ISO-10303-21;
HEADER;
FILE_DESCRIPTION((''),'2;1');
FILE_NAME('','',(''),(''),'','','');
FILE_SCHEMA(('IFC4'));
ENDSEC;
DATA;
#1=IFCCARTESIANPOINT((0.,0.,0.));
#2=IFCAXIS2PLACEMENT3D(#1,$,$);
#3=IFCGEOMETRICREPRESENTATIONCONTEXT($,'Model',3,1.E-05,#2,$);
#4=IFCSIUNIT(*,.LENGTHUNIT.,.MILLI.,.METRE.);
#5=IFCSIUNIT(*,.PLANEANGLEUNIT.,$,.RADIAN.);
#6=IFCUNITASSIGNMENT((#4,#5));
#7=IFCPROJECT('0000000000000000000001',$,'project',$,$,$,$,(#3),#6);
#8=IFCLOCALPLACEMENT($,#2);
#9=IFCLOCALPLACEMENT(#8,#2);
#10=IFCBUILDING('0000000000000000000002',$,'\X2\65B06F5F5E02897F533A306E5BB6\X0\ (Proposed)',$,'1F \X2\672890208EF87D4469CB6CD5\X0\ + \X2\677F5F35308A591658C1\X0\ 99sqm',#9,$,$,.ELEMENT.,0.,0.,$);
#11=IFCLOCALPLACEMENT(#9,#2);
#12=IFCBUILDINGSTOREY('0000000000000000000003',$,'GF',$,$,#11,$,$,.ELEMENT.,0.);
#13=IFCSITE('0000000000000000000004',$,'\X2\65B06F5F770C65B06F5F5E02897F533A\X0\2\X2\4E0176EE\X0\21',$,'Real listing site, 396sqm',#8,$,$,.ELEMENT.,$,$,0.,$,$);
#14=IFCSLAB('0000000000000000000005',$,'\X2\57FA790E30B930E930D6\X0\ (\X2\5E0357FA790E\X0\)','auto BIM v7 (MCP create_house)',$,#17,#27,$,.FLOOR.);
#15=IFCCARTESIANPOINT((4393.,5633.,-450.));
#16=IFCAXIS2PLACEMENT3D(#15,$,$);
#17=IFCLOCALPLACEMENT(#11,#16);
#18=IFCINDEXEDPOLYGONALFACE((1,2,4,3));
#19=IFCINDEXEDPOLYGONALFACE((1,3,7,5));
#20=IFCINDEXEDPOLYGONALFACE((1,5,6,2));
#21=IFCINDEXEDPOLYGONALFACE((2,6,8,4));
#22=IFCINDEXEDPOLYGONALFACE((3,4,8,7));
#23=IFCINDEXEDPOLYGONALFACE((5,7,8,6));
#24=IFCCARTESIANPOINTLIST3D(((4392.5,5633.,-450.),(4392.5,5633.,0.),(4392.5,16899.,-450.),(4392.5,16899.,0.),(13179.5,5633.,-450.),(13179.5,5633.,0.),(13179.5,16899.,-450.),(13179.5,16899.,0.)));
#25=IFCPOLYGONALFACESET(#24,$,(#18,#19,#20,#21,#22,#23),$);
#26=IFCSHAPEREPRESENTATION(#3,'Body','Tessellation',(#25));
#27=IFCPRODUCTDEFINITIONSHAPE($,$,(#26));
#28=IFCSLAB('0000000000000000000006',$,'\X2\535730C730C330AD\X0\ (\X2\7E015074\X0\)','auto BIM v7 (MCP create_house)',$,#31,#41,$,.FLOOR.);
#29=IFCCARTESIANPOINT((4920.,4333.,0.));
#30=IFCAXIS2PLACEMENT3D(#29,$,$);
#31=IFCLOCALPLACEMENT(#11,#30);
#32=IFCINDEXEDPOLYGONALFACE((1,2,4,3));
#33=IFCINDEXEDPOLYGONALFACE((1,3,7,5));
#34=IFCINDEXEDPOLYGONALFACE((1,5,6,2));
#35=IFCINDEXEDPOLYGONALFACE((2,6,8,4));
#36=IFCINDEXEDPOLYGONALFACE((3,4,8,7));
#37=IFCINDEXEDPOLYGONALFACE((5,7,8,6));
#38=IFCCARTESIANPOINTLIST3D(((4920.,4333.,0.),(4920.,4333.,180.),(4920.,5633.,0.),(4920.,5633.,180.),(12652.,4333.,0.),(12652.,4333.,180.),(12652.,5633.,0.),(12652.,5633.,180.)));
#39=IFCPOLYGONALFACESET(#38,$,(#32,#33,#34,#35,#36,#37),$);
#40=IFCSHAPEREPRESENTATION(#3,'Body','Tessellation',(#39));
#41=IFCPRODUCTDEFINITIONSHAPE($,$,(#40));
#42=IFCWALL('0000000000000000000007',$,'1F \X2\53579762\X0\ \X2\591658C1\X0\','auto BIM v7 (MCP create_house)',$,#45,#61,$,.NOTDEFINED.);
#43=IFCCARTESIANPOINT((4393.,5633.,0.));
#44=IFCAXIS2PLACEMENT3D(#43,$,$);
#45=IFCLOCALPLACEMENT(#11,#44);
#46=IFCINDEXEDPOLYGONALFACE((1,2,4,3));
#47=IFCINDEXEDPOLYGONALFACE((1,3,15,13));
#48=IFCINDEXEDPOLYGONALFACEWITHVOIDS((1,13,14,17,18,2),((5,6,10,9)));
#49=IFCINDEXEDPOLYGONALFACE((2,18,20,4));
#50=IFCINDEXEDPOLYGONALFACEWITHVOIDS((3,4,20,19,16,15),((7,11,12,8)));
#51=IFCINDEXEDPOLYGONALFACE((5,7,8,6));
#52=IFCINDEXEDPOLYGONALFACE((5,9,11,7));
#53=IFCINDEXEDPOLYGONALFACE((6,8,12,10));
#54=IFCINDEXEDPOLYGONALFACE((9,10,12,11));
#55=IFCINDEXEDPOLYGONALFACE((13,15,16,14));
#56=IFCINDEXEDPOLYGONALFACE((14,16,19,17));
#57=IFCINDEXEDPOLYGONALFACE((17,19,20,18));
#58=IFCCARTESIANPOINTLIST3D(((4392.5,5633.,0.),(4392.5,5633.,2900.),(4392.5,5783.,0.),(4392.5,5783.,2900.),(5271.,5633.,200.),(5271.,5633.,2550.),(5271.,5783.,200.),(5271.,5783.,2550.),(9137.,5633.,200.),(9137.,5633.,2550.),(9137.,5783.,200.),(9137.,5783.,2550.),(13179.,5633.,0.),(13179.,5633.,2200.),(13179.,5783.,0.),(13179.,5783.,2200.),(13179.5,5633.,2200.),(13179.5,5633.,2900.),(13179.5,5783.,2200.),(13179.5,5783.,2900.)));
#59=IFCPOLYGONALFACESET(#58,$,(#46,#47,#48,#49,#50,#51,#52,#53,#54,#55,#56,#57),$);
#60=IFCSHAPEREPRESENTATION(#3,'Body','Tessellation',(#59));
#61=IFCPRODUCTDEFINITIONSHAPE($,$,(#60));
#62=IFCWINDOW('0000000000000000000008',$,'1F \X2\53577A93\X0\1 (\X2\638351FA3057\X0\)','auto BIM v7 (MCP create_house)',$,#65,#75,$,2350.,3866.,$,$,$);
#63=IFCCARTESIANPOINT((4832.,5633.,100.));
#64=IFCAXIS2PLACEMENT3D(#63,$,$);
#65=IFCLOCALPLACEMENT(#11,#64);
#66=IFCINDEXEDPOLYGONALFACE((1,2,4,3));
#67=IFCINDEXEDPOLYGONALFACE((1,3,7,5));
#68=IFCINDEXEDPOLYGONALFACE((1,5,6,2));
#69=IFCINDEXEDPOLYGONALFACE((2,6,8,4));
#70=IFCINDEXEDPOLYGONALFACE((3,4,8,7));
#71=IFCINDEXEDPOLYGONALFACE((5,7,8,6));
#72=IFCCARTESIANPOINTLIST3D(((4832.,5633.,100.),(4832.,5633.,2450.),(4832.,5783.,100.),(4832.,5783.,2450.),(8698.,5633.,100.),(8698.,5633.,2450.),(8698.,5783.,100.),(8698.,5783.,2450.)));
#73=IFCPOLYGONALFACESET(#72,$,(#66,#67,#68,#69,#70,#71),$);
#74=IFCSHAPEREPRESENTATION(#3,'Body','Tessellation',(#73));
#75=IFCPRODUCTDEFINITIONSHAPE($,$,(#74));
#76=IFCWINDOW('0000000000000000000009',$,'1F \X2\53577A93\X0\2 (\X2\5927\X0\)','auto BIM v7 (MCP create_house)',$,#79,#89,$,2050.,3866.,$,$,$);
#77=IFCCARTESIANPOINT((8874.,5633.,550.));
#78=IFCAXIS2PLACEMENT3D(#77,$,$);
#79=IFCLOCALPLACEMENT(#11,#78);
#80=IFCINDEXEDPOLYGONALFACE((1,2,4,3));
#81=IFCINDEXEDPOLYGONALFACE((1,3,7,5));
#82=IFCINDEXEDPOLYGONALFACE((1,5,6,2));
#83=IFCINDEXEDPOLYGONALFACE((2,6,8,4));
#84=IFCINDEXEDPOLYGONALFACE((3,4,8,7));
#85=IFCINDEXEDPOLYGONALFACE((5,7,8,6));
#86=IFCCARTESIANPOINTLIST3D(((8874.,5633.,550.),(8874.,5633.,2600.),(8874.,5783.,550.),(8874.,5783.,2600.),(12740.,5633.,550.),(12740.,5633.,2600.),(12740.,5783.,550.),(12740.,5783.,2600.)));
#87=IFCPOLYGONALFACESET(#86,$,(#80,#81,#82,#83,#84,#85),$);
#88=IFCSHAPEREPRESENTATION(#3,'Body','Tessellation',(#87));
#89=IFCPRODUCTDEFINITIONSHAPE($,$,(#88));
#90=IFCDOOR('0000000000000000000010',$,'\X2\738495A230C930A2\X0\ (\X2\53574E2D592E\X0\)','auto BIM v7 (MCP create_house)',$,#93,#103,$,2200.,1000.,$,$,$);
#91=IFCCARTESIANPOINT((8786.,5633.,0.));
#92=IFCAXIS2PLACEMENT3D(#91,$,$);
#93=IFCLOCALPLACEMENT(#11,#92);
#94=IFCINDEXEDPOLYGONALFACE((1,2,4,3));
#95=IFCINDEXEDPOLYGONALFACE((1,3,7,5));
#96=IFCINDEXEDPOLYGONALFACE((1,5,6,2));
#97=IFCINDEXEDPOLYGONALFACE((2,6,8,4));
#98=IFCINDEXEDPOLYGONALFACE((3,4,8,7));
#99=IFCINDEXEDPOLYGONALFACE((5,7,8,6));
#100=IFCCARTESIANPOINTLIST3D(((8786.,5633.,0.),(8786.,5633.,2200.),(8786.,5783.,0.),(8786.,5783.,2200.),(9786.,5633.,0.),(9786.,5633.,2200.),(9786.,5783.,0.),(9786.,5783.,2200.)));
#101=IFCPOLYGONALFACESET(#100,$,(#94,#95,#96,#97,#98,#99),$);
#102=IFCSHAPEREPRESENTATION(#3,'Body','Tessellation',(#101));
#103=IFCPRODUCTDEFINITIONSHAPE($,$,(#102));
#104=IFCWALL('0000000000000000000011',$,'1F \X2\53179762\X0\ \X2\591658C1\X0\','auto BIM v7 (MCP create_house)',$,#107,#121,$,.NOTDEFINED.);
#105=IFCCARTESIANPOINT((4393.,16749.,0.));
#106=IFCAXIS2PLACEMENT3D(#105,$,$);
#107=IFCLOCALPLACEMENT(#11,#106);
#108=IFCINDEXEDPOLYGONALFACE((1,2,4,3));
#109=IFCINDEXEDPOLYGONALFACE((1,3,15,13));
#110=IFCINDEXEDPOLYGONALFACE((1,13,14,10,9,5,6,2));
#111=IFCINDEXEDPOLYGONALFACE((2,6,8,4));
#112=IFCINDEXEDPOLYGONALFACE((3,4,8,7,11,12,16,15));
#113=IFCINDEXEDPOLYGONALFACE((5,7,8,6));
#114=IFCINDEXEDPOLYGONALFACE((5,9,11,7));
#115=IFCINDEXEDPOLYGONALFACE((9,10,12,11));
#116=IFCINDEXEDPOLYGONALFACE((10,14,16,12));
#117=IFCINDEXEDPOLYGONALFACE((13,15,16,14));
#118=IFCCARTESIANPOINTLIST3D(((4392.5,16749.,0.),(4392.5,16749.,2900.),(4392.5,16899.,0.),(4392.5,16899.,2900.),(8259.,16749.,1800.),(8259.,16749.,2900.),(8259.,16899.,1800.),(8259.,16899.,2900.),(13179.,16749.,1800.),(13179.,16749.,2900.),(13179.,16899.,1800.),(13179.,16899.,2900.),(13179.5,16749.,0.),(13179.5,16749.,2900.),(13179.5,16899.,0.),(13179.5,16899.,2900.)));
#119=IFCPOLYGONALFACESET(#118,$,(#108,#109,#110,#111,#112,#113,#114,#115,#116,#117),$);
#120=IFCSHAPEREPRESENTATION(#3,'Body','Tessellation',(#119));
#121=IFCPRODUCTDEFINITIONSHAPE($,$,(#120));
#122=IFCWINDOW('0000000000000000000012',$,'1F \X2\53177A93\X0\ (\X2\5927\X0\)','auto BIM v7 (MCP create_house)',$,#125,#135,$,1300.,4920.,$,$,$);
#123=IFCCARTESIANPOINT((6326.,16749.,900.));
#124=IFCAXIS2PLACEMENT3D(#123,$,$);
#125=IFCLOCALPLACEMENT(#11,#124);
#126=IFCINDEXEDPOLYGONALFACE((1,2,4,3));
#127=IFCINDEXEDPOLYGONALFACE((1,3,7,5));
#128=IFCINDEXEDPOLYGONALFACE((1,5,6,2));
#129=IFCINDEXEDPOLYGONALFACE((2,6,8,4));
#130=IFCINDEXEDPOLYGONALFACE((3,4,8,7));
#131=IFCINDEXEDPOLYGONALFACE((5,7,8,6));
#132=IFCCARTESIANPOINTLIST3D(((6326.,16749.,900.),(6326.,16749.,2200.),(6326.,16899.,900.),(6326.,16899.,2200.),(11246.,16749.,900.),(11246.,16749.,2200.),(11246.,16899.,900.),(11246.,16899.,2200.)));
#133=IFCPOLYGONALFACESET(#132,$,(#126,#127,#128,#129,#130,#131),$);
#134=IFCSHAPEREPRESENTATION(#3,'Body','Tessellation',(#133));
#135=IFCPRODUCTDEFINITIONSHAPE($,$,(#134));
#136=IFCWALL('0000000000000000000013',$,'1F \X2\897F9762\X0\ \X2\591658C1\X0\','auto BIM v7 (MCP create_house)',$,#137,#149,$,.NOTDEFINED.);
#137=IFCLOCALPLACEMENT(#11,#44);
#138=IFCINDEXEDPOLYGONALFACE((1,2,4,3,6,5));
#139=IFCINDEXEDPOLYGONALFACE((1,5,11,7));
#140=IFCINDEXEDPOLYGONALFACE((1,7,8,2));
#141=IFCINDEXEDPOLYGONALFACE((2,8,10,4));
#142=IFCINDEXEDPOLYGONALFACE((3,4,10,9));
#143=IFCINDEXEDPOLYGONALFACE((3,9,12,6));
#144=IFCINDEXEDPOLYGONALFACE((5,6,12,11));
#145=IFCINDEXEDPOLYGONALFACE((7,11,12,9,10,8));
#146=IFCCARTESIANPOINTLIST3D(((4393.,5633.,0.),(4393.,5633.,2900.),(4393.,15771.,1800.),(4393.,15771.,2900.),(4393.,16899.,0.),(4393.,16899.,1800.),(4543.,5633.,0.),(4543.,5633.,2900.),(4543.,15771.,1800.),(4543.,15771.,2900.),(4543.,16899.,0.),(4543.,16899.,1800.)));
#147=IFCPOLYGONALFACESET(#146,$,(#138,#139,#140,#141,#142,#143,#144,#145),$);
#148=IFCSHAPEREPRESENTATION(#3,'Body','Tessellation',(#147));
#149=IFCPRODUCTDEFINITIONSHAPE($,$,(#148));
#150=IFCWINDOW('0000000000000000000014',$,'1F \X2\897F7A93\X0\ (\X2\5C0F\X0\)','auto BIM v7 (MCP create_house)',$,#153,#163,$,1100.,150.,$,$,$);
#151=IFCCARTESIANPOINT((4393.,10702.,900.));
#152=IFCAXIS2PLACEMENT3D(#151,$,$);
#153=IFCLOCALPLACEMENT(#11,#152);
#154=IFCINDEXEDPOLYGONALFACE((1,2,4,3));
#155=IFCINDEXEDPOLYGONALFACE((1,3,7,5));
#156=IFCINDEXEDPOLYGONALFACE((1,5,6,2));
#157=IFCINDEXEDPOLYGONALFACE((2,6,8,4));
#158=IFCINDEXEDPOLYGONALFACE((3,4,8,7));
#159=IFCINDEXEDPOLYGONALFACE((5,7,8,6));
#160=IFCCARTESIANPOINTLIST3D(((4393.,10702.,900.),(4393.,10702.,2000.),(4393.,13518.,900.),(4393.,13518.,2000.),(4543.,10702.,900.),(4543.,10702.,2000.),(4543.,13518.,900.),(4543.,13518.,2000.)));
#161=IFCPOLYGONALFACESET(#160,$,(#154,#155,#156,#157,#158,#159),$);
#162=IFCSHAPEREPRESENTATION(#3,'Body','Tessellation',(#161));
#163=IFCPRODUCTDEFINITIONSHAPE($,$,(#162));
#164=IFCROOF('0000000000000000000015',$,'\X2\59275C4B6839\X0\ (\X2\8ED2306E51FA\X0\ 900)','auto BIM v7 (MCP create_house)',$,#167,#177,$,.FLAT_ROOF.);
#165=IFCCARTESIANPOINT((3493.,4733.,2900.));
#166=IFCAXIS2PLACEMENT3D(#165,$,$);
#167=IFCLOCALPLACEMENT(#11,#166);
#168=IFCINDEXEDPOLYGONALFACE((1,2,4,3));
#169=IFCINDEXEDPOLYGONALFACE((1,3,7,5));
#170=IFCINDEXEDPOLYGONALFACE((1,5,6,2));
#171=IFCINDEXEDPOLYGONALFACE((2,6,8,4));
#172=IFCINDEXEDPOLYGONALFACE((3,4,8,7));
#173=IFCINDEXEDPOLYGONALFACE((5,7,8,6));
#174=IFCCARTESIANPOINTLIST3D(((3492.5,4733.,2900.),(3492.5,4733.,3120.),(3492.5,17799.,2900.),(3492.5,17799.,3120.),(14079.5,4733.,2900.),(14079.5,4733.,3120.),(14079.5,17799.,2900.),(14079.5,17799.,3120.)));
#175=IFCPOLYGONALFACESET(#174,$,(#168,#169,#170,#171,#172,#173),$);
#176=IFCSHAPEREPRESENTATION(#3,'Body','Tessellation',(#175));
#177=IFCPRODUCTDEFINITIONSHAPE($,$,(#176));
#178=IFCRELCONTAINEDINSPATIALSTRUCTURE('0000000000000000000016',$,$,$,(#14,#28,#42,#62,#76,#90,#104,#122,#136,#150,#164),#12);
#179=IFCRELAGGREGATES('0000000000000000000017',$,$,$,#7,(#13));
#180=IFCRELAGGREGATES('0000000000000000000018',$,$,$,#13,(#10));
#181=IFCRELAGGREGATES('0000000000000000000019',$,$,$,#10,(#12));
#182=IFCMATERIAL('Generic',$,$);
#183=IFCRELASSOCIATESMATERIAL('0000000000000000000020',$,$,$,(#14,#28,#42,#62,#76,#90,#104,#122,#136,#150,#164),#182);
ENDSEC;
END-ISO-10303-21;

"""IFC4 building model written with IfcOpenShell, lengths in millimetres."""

from ifc_helpers import new_model, si_unit, frame, frame_2d, origin, place, context, project, spatial, rectangle, extrude, material, element, fill, save


model = new_model("IFC4")

# Units and contexts
model_context = context("Model", 3, precision=1e-05, world=origin())
ifc_project = project(units=[si_unit("LENGTHUNIT", "METRE", prefix="MILLI"), si_unit("PLANEANGLEUNIT", "RADIAN")], contexts=[model_context])

# Site, building, storey
site_placement = place(None, origin())
site = spatial("IfcSite", under=ifc_project, at=site_placement, Name="新潟県新潟市西区2丁目21", ObjectType="Real listing site, 396sqm", CompositionType="ELEMENT", RefElevation=0.0)
building_placement = place(site_placement, origin())
building = spatial("IfcBuilding", under=site, at=building_placement, Name="新潟市西区の家 (Proposed)", ObjectType="1F 木造軸組構法 + 板張り外壁 99sqm", CompositionType="ELEMENT", ElevationOfRefHeight=0.0, ElevationOfTerrain=0.0)
storey_placement = place(building_placement, origin())
storey = spatial("IfcBuildingStorey", under=building, at=storey_placement, Name="GF", CompositionType="ELEMENT", Elevation=0.0)

# Slabs
ifc_material = material(Name="Generic")
slab_1_placement = place(storey_placement, frame((4393.0, 5633.0, -450.0)))
element("IfcSlab", 1, at=slab_1_placement, inside=storey, material=ifc_material, Name="基礎スラブ (布基礎)", Description="auto BIM v7 (MCP create_house)", PredefinedType="FLOOR", context=model_context, shape_type="SweptSolid", body=[
    extrude(rectangle(XDim=8787.0, YDim=11266.0, at=frame_2d((4393.0, 5633.0))), frame((4393.0, 5633.0, -450.0)), (0.0, 0.0, 1.0), 450.0),
])
slab_2_placement = place(storey_placement, frame((4920.0, 4333.0, 0.0)))
element("IfcSlab", 2, at=slab_2_placement, inside=storey, material=ifc_material, Name="南デッキ (縁側)", Description="auto BIM v7 (MCP create_house)", PredefinedType="FLOOR", context=model_context, shape_type="SweptSolid", body=[
    extrude(rectangle(XDim=7732.0, YDim=1300.0, at=frame_2d((3866.0, 650.0))), frame((4920.0, 4333.0, 0.0)), (0.0, 0.0, 1.0), 180.0),
])

# Wall, openings, windows, door
wall_1_placement = place(storey_placement, frame((4393.0, 5633.0, 0.0)))
wall_1 = element("IfcWall", 3, at=wall_1_placement, inside=storey, material=ifc_material, Name="1F 南面 外壁", Description="auto BIM v7 (MCP create_house)", PredefinedType="NOTDEFINED", context=model_context, shape_type="SweptSolid", body=[
    extrude(rectangle(XDim=8787.0, YDim=150.0, at=frame_2d((4393.0, 75.0))), frame((4393.0, 5633.0, 0.0)), (0.0, 0.0, 1.0), 2900.0),
])
opening_1_placement = place(storey_placement, frame((4832.0, 5633.0, 100.0)))
opening_1 = element("IfcOpeningElement", 4, at=opening_1_placement, cuts=wall_1, PredefinedType="NOTDEFINED", context=model_context, shape_type="SweptSolid", body=[
    extrude(rectangle(XDim=3866.0, YDim=150.0, at=frame_2d((1933.0, 75.0))), frame((4832.0, 5633.0, 100.0)), (0.0, 0.0, 1.0), 2350.0),
])
opening_2_placement = place(storey_placement, frame((8874.0, 5633.0, 550.0)))
opening_2 = element("IfcOpeningElement", 5, at=opening_2_placement, cuts=wall_1, PredefinedType="NOTDEFINED", context=model_context, shape_type="SweptSolid", body=[
    extrude(rectangle(XDim=3866.0, YDim=150.0, at=frame_2d((1933.0, 75.0))), frame((8874.0, 5633.0, 550.0)), (0.0, 0.0, 1.0), 2050.0),
])
opening_3_placement = place(storey_placement, frame((8786.0, 5633.0, 0.0)))
opening_3 = element("IfcOpeningElement", 6, at=opening_3_placement, cuts=wall_1, PredefinedType="NOTDEFINED", context=model_context, shape_type="SweptSolid", body=[
    extrude(rectangle(XDim=1000.0, YDim=150.0, at=frame_2d((500.0, 75.0))), frame((8786.0, 5633.0, 0.0)), (0.0, 0.0, 1.0), 2200.0),
])
window_1_placement = place(storey_placement, frame((4832.0, 5633.0, 100.0)))
window_1 = element("IfcWindow", 7, at=window_1_placement, inside=storey, material=ifc_material, Name="1F 南窓1 (掃出し)", Description="auto BIM v7 (MCP create_house)", OverallHeight=2350.0, OverallWidth=3866.0, context=model_context, shape_type="SweptSolid", body=[
    extrude(rectangle(XDim=3866.0, YDim=150.0, at=frame_2d((1933.0, 75.0))), frame((4832.0, 5633.0, 100.0)), (0.0, 0.0, 1.0), 2350.0),
])
fill(opening_1, window_1)
window_2_placement = place(storey_placement, frame((8874.0, 5633.0, 550.0)))
window_2 = element("IfcWindow", 8, at=window_2_placement, inside=storey, material=ifc_material, Name="1F 南窓2 (大)", Description="auto BIM v7 (MCP create_house)", OverallHeight=2050.0, OverallWidth=3866.0, context=model_context, shape_type="SweptSolid", body=[
    extrude(rectangle(XDim=3866.0, YDim=150.0, at=frame_2d((1933.0, 75.0))), frame((8874.0, 5633.0, 550.0)), (0.0, 0.0, 1.0), 2050.0),
])
fill(opening_2, window_2)
door_placement = place(storey_placement, frame((8786.0, 5633.0, 0.0)))
door = element("IfcDoor", 9, at=door_placement, inside=storey, material=ifc_material, Name="玄関ドア (南中央)", Description="auto BIM v7 (MCP create_house)", OverallHeight=2200.0, OverallWidth=1000.0, context=model_context, shape_type="SweptSolid", body=[
    extrude(rectangle(XDim=1000.0, YDim=150.0, at=frame_2d((500.0, 75.0))), frame((8786.0, 5633.0, 0.0)), (0.0, 0.0, 1.0), 2200.0),
])
fill(opening_3, door)

# Walls, openings, windows
wall_2_placement = place(storey_placement, frame((4393.0, 16749.0, 0.0)))
wall_2 = element("IfcWall", 10, at=wall_2_placement, inside=storey, material=ifc_material, Name="1F 北面 外壁", Description="auto BIM v7 (MCP create_house)", PredefinedType="NOTDEFINED", context=model_context, shape_type="SweptSolid", body=[
    extrude(rectangle(XDim=8787.0, YDim=150.0, at=frame_2d((4393.0, 75.0))), frame((4393.0, 16749.0, 0.0)), (0.0, 0.0, 1.0), 2900.0),
])
opening_4_placement = place(storey_placement, frame((6326.0, 16749.0, 900.0)))
opening_4 = element("IfcOpeningElement", 11, at=opening_4_placement, cuts=wall_2, PredefinedType="NOTDEFINED", context=model_context, shape_type="SweptSolid", body=[
    extrude(rectangle(XDim=4920.0, YDim=150.0, at=frame_2d((2460.0, 75.0))), frame((6326.0, 16749.0, 900.0)), (0.0, 0.0, 1.0), 1300.0),
])
window_3_placement = place(storey_placement, frame((6326.0, 16749.0, 900.0)))
window_3 = element("IfcWindow", 12, at=window_3_placement, inside=storey, material=ifc_material, Name="1F 北窓 (大)", Description="auto BIM v7 (MCP create_house)", OverallHeight=1300.0, OverallWidth=4920.0, context=model_context, shape_type="SweptSolid", body=[
    extrude(rectangle(XDim=4920.0, YDim=150.0, at=frame_2d((2460.0, 75.0))), frame((6326.0, 16749.0, 900.0)), (0.0, 0.0, 1.0), 1300.0),
])
fill(opening_4, window_3)
wall_3_placement = place(storey_placement, frame((4393.0, 5633.0, 0.0)))
wall_3 = element("IfcWall", 13, at=wall_3_placement, inside=storey, material=ifc_material, Name="1F 西面 外壁", Description="auto BIM v7 (MCP create_house)", PredefinedType="NOTDEFINED", context=model_context, shape_type="SweptSolid", body=[
    extrude(rectangle(XDim=150.0, YDim=11266.0, at=frame_2d((75.0, 5633.0))), frame((4393.0, 5633.0, 0.0)), (0.0, 0.0, 1.0), 2900.0),
])
opening_5_placement = place(storey_placement, frame((4393.0, 10702.0, 900.0)))
opening_5 = element("IfcOpeningElement", 14, at=opening_5_placement, cuts=wall_3, PredefinedType="NOTDEFINED", context=model_context, shape_type="SweptSolid", body=[
    extrude(rectangle(XDim=150.0, YDim=2816.0, at=frame_2d((75.0, 1408.0))), frame((4393.0, 10702.0, 900.0)), (0.0, 0.0, 1.0), 1100.0),
])
window_4_placement = place(storey_placement, frame((4393.0, 10702.0, 900.0)))
window_4 = element("IfcWindow", 15, at=window_4_placement, inside=storey, material=ifc_material, Name="1F 西窓 (小)", Description="auto BIM v7 (MCP create_house)", OverallHeight=1100.0, OverallWidth=150.0, context=model_context, shape_type="SweptSolid", body=[
    extrude(rectangle(XDim=150.0, YDim=2816.0, at=frame_2d((75.0, 1408.0))), frame((4393.0, 10702.0, 900.0)), (0.0, 0.0, 1.0), 1100.0),
])
fill(opening_5, window_4)

# Roof
roof_placement = place(storey_placement, frame((3493.0, 4733.0, 2900.0)))
element("IfcRoof", 16, at=roof_placement, inside=storey, material=ifc_material, Name="大屋根 (軒の出 900)", Description="auto BIM v7 (MCP create_house)", PredefinedType="FLAT_ROOF", context=model_context, shape_type="SweptSolid", body=[
    extrude(rectangle(XDim=10587.0, YDim=13066.0, at=frame_2d((5293.0, 6533.0))), frame((3493.0, 4733.0, 2900.0)), (0.0, 0.0, 1.0), 220.0),
])

save(model, "model.ifc")
